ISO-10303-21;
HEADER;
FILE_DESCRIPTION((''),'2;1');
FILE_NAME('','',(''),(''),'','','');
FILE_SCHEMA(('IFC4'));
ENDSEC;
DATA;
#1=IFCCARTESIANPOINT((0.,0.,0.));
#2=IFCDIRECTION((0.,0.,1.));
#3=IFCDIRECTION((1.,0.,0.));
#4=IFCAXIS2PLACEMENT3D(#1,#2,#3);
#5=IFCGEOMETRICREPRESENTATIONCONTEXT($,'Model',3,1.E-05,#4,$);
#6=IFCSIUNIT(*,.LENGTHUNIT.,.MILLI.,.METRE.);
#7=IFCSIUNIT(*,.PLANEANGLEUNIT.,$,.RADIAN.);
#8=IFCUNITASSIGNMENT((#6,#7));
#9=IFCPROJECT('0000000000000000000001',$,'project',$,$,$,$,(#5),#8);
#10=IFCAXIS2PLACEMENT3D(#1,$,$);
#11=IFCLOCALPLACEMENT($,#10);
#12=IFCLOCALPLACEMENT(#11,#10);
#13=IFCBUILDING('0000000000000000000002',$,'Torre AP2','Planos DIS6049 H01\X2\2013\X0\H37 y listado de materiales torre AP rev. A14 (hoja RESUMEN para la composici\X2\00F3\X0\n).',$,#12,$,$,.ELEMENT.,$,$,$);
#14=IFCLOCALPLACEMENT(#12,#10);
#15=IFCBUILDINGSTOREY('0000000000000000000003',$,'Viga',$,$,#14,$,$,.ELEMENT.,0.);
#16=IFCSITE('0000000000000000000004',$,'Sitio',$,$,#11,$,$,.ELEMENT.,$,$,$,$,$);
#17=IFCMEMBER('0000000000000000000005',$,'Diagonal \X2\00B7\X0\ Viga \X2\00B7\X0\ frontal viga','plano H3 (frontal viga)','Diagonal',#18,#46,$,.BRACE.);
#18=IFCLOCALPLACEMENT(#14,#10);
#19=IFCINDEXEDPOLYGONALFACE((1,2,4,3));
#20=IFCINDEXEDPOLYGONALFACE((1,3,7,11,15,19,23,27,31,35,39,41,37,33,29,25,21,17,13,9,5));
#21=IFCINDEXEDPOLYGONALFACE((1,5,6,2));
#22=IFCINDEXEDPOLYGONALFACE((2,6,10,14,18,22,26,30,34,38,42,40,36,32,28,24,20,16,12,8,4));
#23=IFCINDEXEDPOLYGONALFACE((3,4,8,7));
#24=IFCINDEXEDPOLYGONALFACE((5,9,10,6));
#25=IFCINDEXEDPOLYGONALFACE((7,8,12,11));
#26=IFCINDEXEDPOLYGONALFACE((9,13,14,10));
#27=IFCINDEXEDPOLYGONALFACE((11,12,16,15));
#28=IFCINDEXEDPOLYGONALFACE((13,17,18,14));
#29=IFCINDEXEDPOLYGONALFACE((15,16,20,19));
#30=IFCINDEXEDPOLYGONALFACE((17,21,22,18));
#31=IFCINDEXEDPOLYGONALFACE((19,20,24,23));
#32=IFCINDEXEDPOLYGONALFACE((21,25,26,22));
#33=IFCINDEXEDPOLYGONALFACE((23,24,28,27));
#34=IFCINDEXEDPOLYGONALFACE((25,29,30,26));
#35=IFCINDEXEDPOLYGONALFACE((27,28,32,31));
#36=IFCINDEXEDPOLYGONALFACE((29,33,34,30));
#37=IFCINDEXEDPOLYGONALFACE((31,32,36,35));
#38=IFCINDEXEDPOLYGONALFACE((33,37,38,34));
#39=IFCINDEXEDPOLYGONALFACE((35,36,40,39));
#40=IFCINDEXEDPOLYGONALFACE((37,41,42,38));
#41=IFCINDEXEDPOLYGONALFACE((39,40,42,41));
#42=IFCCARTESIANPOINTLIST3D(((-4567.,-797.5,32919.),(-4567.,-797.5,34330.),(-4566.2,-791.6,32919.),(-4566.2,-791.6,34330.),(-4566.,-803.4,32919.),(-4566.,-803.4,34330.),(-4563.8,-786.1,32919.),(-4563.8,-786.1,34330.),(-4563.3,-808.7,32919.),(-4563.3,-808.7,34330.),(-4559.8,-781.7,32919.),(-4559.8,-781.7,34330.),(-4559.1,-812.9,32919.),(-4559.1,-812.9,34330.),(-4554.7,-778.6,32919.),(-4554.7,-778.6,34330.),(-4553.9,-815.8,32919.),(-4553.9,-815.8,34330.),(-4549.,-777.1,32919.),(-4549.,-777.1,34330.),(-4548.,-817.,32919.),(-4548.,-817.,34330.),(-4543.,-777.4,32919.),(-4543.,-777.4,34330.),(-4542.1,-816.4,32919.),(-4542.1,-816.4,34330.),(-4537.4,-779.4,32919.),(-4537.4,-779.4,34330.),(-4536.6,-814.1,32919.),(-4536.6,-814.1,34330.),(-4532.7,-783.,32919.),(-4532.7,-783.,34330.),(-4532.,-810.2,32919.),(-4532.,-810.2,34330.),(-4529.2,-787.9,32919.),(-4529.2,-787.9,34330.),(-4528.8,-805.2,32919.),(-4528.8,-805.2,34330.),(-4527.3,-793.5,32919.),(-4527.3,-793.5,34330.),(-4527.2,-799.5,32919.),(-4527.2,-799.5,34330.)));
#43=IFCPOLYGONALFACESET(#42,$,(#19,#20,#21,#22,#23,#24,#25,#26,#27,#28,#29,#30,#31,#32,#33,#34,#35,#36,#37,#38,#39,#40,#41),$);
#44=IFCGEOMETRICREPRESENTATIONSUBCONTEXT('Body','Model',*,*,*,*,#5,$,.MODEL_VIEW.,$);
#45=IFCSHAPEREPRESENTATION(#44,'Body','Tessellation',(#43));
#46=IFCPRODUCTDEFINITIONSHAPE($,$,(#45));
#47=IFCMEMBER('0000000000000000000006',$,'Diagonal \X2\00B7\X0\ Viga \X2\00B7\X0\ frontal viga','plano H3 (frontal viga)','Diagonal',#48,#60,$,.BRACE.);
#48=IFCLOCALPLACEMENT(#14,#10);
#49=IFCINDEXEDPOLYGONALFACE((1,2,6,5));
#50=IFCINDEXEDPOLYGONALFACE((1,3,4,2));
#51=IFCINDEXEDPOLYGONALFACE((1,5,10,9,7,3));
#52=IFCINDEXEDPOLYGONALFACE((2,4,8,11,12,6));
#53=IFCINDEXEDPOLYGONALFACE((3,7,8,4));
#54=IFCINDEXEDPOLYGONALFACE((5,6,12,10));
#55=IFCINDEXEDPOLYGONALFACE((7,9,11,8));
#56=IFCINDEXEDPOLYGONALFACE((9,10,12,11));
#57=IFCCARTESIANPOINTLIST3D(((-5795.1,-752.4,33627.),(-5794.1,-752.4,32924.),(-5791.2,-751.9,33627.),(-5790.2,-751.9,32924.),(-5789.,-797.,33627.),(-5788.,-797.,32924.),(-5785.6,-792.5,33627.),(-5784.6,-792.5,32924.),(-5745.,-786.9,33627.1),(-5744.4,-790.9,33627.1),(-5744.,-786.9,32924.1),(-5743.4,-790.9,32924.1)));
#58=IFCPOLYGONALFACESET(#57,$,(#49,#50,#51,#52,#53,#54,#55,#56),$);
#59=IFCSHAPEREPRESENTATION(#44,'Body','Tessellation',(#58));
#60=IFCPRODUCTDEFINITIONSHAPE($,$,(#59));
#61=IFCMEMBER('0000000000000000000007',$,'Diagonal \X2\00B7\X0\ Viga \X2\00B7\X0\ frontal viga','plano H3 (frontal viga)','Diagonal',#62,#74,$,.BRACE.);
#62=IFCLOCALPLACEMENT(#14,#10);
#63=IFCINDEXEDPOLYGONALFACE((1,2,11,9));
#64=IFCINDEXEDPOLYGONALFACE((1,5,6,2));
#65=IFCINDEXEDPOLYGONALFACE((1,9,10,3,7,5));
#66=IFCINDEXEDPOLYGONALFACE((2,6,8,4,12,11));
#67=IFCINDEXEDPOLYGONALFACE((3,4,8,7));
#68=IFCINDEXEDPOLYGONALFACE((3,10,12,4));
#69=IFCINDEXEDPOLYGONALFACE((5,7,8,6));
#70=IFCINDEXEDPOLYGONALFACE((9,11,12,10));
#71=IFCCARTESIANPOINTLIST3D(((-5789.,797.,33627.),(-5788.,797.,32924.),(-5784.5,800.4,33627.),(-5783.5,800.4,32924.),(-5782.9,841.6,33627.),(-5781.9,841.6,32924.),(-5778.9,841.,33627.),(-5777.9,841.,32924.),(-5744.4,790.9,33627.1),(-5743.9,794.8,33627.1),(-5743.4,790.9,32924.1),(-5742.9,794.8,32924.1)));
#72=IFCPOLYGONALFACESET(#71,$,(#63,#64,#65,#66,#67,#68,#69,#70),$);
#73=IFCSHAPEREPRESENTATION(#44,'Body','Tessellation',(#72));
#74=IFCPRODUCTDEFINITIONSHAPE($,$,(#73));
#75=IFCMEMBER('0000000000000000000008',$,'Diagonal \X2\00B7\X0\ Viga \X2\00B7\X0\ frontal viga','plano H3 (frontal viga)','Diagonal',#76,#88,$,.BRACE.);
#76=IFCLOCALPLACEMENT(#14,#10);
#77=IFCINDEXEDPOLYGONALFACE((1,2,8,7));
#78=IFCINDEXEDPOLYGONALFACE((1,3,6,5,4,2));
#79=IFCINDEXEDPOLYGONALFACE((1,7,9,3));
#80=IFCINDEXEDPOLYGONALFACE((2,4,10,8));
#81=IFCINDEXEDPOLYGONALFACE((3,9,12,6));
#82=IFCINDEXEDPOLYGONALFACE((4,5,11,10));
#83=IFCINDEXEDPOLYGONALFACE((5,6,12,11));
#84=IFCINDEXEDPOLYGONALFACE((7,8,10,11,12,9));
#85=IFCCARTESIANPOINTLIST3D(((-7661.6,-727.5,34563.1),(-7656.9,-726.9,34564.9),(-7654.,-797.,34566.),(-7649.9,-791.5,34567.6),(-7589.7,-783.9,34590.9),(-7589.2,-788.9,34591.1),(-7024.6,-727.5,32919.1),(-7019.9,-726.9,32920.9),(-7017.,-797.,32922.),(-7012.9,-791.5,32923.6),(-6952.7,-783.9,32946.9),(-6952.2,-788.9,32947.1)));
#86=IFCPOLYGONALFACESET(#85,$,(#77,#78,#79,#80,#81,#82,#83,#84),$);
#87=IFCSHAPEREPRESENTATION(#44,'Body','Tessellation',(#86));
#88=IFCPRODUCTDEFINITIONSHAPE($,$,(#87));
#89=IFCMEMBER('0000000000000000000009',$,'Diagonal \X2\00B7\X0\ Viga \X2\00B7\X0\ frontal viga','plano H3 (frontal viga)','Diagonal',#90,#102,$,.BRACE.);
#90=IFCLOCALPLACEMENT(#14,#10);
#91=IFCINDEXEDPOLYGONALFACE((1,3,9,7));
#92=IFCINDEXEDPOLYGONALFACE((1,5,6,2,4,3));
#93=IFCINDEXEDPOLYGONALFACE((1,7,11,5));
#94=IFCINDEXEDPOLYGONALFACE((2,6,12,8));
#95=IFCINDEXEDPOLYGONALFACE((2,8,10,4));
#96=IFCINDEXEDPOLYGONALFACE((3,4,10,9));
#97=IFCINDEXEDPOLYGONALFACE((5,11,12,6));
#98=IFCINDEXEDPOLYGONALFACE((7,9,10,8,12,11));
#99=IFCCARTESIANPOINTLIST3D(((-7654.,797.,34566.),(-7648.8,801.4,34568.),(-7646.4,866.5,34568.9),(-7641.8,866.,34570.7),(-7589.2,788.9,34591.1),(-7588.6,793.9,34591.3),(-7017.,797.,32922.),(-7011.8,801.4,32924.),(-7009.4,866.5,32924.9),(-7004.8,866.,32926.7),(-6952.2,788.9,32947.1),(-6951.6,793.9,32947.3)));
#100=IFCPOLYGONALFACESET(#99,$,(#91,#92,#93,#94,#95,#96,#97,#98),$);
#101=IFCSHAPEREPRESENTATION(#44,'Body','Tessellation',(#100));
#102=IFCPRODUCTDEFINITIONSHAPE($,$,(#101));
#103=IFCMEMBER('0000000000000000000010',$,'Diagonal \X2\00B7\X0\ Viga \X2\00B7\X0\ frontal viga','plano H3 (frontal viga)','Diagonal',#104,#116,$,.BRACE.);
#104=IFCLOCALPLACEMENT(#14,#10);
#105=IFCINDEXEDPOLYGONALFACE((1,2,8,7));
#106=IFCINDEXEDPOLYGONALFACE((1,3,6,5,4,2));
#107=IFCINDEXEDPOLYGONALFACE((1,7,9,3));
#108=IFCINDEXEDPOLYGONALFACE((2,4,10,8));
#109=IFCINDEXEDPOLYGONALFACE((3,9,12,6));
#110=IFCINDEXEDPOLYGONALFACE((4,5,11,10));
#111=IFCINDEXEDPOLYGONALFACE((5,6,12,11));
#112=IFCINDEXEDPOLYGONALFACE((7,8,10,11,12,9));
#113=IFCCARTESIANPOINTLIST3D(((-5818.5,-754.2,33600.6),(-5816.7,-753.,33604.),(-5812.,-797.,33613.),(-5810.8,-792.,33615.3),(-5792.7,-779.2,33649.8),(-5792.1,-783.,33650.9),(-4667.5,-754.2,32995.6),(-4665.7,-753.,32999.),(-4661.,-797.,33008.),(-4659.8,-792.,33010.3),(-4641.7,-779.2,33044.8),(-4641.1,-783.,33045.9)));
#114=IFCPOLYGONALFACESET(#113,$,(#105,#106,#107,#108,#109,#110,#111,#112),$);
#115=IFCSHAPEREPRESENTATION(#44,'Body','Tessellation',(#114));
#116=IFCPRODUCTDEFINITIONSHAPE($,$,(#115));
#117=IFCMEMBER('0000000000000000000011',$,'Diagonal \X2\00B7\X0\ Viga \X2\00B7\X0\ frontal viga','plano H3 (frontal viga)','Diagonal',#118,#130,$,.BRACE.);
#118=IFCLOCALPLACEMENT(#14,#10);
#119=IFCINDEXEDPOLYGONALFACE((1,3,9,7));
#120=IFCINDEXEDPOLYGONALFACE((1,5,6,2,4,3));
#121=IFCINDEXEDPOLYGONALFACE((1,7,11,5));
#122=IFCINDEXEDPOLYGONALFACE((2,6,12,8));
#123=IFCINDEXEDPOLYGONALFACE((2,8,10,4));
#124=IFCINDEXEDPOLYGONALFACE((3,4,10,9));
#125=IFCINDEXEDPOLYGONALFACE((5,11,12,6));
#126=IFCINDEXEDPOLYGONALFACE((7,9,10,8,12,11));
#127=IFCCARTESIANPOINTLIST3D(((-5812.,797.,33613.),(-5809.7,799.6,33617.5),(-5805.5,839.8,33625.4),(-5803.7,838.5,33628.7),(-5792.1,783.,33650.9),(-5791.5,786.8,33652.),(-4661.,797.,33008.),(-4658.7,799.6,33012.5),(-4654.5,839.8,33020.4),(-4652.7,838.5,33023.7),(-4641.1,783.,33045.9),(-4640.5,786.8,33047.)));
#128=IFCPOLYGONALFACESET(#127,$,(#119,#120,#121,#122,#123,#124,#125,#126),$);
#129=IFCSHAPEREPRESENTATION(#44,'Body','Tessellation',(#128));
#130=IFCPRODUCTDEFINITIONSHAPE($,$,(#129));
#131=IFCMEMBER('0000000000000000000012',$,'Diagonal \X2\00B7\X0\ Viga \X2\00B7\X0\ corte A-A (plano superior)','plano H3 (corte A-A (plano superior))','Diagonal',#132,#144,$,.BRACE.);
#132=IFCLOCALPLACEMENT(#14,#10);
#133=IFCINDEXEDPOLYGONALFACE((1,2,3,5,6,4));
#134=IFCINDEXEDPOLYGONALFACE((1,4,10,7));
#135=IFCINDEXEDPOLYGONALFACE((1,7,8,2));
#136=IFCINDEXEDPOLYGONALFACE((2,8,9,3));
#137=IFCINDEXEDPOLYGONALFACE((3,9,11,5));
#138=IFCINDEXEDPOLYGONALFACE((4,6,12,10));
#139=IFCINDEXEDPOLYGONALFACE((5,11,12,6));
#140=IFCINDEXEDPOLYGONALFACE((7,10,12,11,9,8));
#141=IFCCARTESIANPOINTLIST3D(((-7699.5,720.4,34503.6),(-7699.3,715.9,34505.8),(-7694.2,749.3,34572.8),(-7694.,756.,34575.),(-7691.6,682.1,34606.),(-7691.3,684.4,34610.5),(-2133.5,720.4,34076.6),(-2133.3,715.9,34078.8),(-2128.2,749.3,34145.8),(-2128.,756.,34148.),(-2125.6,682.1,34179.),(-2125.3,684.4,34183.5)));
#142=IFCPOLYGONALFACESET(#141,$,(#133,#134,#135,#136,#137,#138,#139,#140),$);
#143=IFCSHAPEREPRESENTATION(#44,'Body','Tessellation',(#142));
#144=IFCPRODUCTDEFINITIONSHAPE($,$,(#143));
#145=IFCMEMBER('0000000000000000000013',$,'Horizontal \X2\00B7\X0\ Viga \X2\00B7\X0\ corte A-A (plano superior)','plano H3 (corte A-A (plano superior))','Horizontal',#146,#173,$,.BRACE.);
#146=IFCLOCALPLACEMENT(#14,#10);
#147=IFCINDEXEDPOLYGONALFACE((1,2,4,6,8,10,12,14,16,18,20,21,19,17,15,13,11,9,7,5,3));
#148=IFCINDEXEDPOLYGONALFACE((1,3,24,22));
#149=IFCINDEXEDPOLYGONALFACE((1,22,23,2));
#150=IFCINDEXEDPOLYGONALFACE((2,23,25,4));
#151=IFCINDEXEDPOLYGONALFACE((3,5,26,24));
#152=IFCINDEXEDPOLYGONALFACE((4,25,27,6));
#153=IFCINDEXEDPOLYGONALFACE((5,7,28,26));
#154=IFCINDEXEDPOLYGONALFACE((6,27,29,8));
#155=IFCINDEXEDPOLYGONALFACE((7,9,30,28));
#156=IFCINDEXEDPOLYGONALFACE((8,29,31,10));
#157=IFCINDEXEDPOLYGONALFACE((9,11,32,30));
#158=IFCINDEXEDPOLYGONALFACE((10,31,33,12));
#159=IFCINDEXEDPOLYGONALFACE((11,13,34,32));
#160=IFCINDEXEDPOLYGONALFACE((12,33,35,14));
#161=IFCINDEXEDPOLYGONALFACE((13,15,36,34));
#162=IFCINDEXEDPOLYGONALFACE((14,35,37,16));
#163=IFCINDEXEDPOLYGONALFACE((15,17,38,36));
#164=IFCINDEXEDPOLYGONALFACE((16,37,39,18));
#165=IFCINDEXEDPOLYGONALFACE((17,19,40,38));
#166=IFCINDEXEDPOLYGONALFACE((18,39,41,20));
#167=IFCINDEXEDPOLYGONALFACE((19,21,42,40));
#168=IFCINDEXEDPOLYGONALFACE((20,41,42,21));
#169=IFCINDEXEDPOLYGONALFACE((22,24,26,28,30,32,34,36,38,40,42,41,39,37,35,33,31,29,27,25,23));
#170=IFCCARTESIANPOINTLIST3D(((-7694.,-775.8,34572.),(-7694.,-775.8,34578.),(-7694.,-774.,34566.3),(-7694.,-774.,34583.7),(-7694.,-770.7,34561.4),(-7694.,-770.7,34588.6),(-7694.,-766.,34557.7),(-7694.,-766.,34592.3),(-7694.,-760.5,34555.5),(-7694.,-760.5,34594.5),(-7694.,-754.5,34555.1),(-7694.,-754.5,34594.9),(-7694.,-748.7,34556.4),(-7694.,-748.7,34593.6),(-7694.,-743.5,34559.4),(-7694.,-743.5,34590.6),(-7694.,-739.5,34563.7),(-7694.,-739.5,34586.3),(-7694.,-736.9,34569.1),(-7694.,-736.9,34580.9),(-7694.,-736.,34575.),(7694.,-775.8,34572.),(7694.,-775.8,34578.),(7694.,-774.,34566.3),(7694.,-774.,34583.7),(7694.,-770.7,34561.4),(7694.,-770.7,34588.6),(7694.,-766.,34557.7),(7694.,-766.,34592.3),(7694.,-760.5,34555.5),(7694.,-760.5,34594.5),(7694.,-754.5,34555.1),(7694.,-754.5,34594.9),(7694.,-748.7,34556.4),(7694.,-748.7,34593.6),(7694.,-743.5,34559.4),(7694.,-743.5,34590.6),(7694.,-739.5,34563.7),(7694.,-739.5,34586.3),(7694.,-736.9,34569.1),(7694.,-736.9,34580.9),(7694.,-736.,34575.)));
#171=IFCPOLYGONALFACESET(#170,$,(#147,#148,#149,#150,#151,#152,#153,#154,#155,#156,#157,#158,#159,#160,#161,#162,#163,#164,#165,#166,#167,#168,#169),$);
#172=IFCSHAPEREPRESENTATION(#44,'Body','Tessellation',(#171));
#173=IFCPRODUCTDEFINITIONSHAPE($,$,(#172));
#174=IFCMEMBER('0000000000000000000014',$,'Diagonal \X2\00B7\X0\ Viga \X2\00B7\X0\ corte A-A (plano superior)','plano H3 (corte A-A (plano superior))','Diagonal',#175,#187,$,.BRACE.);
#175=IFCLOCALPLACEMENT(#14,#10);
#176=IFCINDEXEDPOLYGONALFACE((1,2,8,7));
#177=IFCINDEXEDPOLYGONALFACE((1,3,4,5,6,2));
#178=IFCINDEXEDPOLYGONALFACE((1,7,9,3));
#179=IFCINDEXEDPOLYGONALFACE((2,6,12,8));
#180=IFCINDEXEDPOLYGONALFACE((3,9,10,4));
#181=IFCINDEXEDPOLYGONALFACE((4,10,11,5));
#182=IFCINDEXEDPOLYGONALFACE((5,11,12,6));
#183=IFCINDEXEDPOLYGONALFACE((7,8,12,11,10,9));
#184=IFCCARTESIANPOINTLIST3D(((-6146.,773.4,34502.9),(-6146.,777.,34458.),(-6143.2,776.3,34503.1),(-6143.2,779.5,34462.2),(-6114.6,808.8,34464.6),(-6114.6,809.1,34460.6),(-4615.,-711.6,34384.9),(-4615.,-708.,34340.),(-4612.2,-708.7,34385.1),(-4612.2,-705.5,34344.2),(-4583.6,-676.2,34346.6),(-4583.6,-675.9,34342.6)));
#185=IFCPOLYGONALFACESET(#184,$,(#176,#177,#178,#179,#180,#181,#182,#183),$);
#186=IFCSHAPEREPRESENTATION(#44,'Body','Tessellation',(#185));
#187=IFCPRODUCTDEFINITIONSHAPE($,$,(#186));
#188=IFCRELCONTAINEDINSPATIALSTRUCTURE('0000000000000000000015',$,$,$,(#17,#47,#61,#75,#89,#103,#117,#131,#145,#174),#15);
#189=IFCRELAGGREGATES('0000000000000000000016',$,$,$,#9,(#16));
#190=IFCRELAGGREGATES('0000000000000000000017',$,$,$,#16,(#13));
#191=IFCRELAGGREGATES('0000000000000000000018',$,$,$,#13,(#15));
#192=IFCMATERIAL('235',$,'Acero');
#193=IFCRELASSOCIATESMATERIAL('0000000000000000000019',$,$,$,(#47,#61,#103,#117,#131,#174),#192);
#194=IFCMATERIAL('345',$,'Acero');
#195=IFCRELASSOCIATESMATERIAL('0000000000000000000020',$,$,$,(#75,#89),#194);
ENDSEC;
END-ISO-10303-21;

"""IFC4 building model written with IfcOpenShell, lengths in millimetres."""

from ifc_helpers import new_model, si_unit, frame, frame_2d, origin, origin_with_axes, place, context, subcontext, project, spatial, circle, l_section, extrude, material, element, save


model = new_model("IFC4")

# Units and contexts
model_context = context("Model", 3, precision=1e-05, world=origin_with_axes())
body_context = subcontext(model_context, "Body", "Model", "MODEL_VIEW")
ifc_project = project(units=[si_unit("LENGTHUNIT", "METRE", prefix="MILLI"), si_unit("PLANEANGLEUNIT", "RADIAN")], contexts=[model_context])

# Site, building, storey
site_placement = place(None, origin())
site = spatial("IfcSite", under=ifc_project, at=site_placement, Name="Sitio", CompositionType="ELEMENT")
building_placement = place(site_placement, origin())
building = spatial("IfcBuilding", under=site, at=building_placement, Name="Torre AP2", Description="Planos DIS6049 H01–H37 y listado de materiales torre AP rev. A14 (hoja RESUMEN para la composición).", CompositionType="ELEMENT")
storey_placement = place(building_placement, origin())
storey = spatial("IfcBuildingStorey", under=building, at=storey_placement, Name="Viga", CompositionType="ELEMENT", Elevation=0.0)

# Members
ifc_material_1 = material(Name="345", Category="Acero")
member_1_placement = place(storey_placement, frame((-4547.0, -797.0, 32919.0), z_axis=(0.0, 0.0, 1.0), x_axis=(0.984984, 0.172648, 0.0)))
element("IfcMember", 1, at=member_1_placement, inside=storey, Name="Diagonal · Viga · frontal viga", Description="plano H3 (frontal viga)", ObjectType="Diagonal", PredefinedType="BRACE", context=body_context, shape_type="SweptSolid", body=[
    extrude(circle(Radius=20.0), None, (0.0, 0.0, 1.0), 1411.0),
])
ifc_material_2 = material(Name="235", Category="Acero")
for number, where, z_axis, x_axis, name in (
    (2, (-5788.0, -797.0, 32924.0), (-0.001422, 0.0, 0.999999), (0.990653, 0.1364, 0.001409), "Diagonal · Viga · frontal viga"),
    (3, (-5788.0, 797.0, 32924.0), (-0.001422, 0.0, 0.999999), (0.990653, -0.1364, 0.001409), "Diagonal · Viga · frontal viga"),
):
    element("IfcMember", number, at=place(storey_placement, frame(where, z_axis=z_axis, x_axis=x_axis)), inside=storey, material=ifc_material_2, Name=name, Description="plano H3 (frontal viga)", ObjectType="Diagonal", PredefinedType="BRACE", context=body_context, shape_type="SweptSolid", body=[
        extrude(l_section(Depth=45.0, Width=45.0, Thickness=4.0, at=frame_2d((22.5, 22.5))), None, (0.0, 0.0, 1.0), 703.0),
    ])
for number, where, z_axis, x_axis, name in (
    (4, (-7017.0, -797.0, 32922.0), (-0.361296, 0.0, 0.932451), (0.926185, 0.115738, 0.358868), "Diagonal · Viga · frontal viga"),
    (5, (-7017.0, 797.0, 32922.0), (-0.361296, 0.0, 0.932451), (0.926185, -0.115738, 0.358868), "Diagonal · Viga · frontal viga"),
):
    element("IfcMember", number, at=place(storey_placement, frame(where, z_axis=z_axis, x_axis=x_axis)), inside=storey, material=ifc_material_1, Name=name, Description="plano H3 (frontal viga)", ObjectType="Diagonal", PredefinedType="BRACE", context=body_context, shape_type="SweptSolid", body=[
        extrude(l_section(Depth=70.0, Width=70.0, Thickness=5.0, at=frame_2d((35.0, 35.0))), None, (0.0, 0.0, 1.0), 1763.1),
    ])
for number, where, z_axis, x_axis, name in (
    (6, (-4661.0, -797.0, 33008.0), (-0.885168, 0.0, 0.465271), (0.442212, 0.310911, 0.841299), "Diagonal · Viga · frontal viga"),
    (7, (-4661.0, 797.0, 33008.0), (-0.885168, 0.0, 0.465271), (0.442212, -0.310911, 0.841299), "Diagonal · Viga · frontal viga"),
):
    element("IfcMember", number, at=place(storey_placement, frame(where, z_axis=z_axis, x_axis=x_axis)), inside=storey, material=ifc_material_2, Name=name, Description="plano H3 (frontal viga)", ObjectType="Diagonal", PredefinedType="BRACE", context=body_context, shape_type="SweptSolid", body=[
        extrude(l_section(Depth=45.0, Width=45.0, Thickness=4.0, at=frame_2d((22.5, 22.5))), None, (0.0, 0.0, 1.0), 1300.3),
    ])
member_2_placement = place(storey_placement, frame((-7694.0, 756.0, 34575.0), z_axis=(0.99707, 0.0, -0.076491), x_axis=(0.034037, -0.895539, 0.443679)))
element("IfcMember", 8, at=member_2_placement, inside=storey, material=ifc_material_2, Name="Diagonal · Viga · corte A-A (plano superior)", Description="plano H3 (corte A-A (plano superior))", ObjectType="Diagonal", PredefinedType="BRACE", context=body_context, shape_type="SweptSolid", body=[
    extrude(l_section(Depth=80.0, Width=80.0, Thickness=5.0, at=frame_2d((40.0, 40.0))), None, (0.0, 0.0, 1.0), 5582.4),
])
member_3_placement = place(storey_placement, frame((-7694.0, -756.0, 34575.0), z_axis=(1.0, 0.0, 0.0), x_axis=(0.0, 1.0, 0.0)))
element("IfcMember", 9, at=member_3_placement, inside=storey, Name="Horizontal · Viga · corte A-A (plano superior)", Description="plano H3 (corte A-A (plano superior))", ObjectType="Horizontal", PredefinedType="BRACE", context=body_context, shape_type="SweptSolid", body=[
    extrude(circle(Radius=20.0), None, (0.0, 0.0, 1.0), 15388.0),
])
member_4_placement = place(storey_placement, frame((-6146.0, 777.0, 34458.0), z_axis=(0.716712, -0.695178, -0.05524), x_axis=(0.697369, 0.714402, 0.057503)))
element("IfcMember", 10, at=member_4_placement, inside=storey, material=ifc_material_2, Name="Diagonal · Viga · corte A-A (plano superior)", Description="plano H3 (corte A-A (plano superior))", ObjectType="Diagonal", PredefinedType="BRACE", context=body_context, shape_type="SweptSolid", body=[
    extrude(l_section(Depth=45.0, Width=45.0, Thickness=4.0, at=frame_2d((22.5, 22.5))), None, (0.0, 0.0, 1.0), 2136.1),
])

save(model, "model.ifc")
